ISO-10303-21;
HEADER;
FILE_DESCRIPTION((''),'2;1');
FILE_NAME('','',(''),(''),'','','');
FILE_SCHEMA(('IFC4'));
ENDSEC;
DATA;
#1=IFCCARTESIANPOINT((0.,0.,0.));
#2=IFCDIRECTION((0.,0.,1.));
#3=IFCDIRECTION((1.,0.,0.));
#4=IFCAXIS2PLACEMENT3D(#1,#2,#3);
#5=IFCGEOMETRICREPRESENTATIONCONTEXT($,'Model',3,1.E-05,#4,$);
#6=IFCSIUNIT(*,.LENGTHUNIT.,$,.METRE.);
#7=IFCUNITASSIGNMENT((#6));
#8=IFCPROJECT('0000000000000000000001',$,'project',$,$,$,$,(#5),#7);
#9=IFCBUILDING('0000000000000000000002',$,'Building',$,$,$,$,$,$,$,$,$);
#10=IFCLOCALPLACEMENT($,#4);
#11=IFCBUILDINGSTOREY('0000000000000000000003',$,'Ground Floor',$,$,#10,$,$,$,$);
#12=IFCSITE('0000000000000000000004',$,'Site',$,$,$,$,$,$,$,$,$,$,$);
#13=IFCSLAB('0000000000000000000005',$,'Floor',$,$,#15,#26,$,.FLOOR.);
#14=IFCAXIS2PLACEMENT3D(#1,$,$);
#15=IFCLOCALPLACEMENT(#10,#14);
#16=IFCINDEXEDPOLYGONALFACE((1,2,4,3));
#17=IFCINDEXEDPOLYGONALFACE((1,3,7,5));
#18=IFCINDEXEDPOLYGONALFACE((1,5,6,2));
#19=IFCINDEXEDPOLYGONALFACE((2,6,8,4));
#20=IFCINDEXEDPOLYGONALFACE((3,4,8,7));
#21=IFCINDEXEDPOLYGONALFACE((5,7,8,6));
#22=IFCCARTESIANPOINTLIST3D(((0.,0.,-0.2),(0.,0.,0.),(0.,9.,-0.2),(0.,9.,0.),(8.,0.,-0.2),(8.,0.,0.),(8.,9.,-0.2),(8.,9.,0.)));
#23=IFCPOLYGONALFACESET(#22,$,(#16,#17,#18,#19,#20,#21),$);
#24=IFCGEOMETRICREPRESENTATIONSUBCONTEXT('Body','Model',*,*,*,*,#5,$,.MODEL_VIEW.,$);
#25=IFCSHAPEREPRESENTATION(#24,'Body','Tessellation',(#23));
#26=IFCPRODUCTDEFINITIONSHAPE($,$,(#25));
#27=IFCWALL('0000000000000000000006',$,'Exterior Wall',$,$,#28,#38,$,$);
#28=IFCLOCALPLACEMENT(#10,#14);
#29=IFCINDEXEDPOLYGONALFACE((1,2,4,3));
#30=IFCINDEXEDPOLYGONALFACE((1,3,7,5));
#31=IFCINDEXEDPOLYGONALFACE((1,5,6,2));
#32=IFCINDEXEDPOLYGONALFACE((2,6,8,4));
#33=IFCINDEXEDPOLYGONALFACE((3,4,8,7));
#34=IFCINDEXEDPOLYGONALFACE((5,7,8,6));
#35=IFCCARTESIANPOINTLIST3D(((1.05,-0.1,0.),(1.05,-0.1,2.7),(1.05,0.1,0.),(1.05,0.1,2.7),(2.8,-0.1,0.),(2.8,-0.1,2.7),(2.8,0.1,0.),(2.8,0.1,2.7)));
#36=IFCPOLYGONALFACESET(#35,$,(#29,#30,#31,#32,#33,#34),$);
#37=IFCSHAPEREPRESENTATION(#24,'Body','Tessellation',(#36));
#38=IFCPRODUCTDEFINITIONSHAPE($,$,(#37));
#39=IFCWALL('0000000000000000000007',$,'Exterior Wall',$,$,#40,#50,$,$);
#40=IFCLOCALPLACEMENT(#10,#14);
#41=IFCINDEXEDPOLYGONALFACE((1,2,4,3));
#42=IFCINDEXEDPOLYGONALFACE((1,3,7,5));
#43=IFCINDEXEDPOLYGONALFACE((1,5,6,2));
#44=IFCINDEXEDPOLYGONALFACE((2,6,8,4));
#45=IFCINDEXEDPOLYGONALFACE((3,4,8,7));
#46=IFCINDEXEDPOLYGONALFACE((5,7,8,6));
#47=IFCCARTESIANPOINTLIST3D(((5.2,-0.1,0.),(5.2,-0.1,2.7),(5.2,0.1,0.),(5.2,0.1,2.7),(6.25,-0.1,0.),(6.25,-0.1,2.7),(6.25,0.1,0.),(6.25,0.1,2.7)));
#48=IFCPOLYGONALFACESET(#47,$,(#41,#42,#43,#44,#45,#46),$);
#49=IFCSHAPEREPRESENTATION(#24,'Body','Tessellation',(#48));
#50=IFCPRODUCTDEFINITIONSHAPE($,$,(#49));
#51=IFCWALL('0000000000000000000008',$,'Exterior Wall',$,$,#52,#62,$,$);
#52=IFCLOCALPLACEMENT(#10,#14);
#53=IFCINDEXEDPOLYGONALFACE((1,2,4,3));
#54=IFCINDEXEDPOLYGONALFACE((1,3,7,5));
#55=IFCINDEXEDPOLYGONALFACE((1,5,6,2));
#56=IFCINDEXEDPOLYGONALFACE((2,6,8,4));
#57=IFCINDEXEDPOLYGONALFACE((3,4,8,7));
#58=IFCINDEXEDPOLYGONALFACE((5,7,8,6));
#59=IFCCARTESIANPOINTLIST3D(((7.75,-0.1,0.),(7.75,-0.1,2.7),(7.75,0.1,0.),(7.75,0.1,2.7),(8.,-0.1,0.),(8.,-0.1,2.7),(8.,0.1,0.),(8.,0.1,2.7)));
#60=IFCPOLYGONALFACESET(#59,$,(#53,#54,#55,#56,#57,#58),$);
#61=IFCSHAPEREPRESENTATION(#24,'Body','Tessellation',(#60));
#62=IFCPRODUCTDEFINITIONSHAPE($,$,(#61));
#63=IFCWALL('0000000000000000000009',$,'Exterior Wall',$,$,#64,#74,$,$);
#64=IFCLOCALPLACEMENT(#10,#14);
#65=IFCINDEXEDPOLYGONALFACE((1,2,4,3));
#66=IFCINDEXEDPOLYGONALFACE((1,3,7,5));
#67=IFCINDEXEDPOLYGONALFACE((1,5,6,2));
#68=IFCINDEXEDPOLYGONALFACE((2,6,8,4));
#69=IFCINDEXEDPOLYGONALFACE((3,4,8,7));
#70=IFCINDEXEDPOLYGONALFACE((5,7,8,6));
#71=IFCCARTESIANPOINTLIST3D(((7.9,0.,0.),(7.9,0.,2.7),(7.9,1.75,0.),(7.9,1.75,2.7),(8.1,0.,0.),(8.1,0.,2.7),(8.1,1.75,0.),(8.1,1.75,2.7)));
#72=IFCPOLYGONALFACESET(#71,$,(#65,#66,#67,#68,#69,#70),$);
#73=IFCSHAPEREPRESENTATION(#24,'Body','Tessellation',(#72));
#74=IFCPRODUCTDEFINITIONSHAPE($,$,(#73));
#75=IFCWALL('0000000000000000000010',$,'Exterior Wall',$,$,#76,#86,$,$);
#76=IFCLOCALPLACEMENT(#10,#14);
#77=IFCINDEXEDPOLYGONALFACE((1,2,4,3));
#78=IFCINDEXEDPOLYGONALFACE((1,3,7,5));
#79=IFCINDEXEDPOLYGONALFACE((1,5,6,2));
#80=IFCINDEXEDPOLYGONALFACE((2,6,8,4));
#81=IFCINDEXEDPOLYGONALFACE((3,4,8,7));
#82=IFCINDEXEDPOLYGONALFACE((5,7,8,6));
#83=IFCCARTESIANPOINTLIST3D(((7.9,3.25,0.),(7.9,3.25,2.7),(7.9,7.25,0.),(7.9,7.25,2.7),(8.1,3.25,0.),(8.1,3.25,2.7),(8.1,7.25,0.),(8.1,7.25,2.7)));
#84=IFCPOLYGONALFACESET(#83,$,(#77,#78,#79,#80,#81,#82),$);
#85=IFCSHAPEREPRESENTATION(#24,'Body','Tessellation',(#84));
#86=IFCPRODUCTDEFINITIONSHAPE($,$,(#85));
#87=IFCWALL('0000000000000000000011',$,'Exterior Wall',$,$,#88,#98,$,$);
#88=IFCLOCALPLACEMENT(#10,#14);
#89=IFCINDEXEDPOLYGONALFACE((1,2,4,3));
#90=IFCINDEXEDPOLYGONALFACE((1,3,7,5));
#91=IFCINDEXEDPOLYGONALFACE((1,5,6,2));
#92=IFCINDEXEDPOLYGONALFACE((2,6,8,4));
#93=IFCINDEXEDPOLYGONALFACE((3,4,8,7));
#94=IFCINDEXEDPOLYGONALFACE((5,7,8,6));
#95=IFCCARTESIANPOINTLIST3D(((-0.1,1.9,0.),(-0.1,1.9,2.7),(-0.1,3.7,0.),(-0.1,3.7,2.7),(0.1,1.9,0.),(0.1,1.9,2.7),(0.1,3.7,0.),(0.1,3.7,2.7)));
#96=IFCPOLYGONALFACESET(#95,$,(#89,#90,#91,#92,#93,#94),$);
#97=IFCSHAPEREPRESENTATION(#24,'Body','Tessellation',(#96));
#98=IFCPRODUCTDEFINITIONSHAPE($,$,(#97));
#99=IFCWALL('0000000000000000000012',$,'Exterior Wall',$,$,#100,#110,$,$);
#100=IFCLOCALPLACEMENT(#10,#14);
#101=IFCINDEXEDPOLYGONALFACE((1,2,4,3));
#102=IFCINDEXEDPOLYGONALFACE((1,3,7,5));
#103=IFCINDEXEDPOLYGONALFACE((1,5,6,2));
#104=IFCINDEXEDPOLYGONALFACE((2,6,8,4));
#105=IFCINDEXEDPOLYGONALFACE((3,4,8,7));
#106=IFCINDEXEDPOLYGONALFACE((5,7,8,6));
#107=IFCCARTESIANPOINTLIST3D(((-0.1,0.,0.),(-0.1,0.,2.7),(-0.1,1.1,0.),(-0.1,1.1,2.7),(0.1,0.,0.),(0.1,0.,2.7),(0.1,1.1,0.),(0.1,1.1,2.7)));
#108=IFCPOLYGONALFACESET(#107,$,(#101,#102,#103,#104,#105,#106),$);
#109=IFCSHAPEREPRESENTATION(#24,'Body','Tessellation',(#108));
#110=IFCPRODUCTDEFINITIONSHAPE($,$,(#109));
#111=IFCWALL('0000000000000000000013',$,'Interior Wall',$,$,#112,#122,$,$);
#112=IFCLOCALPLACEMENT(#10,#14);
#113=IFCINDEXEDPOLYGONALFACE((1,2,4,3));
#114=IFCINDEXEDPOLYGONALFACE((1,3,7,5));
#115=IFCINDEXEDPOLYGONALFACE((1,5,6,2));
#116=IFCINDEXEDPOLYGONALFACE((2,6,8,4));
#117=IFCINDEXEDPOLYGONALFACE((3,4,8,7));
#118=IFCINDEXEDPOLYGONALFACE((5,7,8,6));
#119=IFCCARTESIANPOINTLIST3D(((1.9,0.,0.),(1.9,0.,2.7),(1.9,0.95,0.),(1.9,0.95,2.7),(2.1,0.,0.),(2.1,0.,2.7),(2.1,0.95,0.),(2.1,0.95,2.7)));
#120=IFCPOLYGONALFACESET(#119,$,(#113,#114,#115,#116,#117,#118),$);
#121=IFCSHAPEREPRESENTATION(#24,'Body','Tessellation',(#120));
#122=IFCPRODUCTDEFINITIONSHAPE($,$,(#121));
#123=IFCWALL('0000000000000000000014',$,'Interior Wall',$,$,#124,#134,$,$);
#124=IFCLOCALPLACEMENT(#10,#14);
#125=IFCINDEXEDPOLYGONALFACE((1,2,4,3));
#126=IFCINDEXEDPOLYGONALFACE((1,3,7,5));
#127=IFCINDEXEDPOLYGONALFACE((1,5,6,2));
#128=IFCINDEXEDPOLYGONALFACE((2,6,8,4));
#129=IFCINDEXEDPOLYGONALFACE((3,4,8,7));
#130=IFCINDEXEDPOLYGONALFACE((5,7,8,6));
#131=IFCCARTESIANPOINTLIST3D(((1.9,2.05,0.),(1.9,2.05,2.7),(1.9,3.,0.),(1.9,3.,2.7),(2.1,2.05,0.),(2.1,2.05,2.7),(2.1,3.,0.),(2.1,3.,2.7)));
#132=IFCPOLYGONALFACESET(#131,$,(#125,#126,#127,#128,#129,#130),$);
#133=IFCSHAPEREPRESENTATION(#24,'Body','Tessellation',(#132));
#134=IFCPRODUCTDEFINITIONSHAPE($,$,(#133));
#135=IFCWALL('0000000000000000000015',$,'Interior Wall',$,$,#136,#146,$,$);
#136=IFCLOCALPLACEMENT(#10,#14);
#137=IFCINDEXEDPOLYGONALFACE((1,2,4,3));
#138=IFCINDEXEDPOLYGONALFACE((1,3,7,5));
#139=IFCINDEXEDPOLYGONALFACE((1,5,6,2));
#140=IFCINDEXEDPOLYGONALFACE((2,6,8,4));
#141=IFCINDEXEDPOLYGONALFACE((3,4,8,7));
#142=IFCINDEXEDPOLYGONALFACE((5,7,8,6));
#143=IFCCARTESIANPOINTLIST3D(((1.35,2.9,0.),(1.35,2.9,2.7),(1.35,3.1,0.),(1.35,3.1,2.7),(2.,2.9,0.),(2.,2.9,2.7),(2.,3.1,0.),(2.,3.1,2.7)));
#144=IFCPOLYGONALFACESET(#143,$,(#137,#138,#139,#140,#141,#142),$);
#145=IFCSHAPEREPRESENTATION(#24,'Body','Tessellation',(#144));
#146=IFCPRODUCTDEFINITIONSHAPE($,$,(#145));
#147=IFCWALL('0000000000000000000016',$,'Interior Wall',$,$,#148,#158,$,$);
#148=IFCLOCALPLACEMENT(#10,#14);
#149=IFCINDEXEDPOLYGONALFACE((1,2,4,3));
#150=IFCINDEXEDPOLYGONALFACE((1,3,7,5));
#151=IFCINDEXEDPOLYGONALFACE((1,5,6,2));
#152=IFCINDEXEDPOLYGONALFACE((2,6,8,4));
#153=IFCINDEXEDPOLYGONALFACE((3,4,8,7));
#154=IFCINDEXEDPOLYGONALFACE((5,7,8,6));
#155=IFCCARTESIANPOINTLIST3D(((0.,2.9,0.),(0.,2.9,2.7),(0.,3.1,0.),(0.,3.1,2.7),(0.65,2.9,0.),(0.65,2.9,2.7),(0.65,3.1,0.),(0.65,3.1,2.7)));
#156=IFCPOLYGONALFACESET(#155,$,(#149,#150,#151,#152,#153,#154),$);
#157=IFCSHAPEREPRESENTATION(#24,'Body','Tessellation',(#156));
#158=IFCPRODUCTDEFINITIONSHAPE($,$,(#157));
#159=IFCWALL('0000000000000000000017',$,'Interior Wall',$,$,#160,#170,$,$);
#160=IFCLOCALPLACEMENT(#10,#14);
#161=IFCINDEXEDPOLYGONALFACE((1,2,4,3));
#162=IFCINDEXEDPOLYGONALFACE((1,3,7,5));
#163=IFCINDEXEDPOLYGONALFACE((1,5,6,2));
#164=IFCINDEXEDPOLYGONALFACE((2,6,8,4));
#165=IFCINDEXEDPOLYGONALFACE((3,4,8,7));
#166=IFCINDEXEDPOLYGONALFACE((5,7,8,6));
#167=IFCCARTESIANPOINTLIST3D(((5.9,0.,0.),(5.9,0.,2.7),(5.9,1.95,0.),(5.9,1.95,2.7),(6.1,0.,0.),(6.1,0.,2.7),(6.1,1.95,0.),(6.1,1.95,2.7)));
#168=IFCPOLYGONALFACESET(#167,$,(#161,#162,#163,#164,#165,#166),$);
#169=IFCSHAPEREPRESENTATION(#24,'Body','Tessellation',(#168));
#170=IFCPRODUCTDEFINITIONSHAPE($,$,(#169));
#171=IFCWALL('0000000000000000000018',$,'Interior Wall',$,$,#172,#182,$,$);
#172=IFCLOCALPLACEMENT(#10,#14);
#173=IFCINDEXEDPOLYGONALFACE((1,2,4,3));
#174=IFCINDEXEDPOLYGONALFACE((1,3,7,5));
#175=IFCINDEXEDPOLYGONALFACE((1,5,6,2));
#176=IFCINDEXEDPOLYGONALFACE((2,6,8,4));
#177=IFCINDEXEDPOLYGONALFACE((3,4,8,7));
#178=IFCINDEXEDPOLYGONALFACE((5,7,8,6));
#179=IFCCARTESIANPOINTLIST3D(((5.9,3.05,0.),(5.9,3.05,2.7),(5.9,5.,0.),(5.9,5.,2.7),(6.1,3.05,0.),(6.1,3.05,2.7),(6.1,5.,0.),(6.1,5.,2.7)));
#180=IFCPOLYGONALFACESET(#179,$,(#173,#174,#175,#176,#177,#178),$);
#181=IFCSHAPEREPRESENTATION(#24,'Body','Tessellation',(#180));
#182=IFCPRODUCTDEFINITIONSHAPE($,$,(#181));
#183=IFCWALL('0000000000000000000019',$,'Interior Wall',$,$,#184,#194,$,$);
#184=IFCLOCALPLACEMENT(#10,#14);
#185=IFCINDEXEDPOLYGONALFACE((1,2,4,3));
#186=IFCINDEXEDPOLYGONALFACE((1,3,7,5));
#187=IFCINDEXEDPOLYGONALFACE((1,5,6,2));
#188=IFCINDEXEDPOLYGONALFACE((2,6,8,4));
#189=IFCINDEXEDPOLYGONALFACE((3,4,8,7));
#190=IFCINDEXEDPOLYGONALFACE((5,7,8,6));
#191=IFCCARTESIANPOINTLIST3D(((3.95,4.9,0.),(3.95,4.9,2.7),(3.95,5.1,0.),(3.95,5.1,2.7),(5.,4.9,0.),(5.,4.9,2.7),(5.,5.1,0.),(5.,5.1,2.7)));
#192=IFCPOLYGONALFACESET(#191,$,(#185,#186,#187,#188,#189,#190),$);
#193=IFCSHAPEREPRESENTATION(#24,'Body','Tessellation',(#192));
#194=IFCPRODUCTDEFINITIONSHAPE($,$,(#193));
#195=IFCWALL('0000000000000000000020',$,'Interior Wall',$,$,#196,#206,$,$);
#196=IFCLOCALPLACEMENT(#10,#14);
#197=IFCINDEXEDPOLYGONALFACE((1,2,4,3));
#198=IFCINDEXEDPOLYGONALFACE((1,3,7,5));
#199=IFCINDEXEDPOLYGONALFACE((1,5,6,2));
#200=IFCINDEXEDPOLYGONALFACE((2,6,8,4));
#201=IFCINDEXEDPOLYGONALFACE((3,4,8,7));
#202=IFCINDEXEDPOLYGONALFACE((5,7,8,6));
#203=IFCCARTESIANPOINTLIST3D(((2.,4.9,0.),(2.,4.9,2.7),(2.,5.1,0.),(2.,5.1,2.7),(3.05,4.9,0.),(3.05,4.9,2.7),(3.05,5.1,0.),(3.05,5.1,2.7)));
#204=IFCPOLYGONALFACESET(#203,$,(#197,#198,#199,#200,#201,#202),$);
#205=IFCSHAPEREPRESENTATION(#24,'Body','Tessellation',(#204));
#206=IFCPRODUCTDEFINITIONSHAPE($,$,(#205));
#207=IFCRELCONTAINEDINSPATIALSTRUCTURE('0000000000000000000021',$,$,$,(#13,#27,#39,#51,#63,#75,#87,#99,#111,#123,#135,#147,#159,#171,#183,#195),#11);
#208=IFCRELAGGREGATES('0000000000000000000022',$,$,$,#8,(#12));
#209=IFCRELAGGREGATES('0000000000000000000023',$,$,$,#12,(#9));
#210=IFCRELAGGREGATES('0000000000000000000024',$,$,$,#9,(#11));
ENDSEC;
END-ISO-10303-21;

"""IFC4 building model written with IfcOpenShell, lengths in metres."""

from ifc_helpers import new_model, si_unit, frame, origin_with_axes, place, context, subcontext, project, spatial, indexed_curve, outline, extrude, element, save


model = new_model("IFC4")

# Units and contexts
model_context = context("Model", 3, precision=1e-05, world=origin_with_axes())
body_context = subcontext(model_context, "Body", "Model", "MODEL_VIEW")
ifc_project = project(units=[si_unit("LENGTHUNIT", "METRE")], contexts=[model_context])

# Site, building, storey
site = spatial("IfcSite", under=ifc_project, Name="Site")
building = spatial("IfcBuilding", under=site, Name="Building")
storey_placement = place(None, origin_with_axes())
storey = spatial("IfcBuildingStorey", under=building, at=storey_placement, Name="Ground Floor")

# Slab
slab_placement = place(storey_placement, frame((0.0, 0.0, -0.2), z_axis=(0.0, 0.0, 1.0), x_axis=(1.0, 0.0, 0.0)))
element("IfcSlab", 1, at=slab_placement, inside=storey, Name="Floor", PredefinedType="FLOOR", context=body_context, shape_type="SweptSolid", body=[
    extrude(outline(indexed_curve([(0.0, 0.0), (8.0, 0.0), (8.0, 9.0), (0.0, 9.0)])), None, (0.0, 0.0, 1.0), 0.2),
])

# Walls
wall_1_placement = place(storey_placement, frame((1.05, 0.0, 0.0), z_axis=(0.0, 0.0, 1.0), x_axis=(1.0, 0.0, 0.0)))
element("IfcWall", 2, at=wall_1_placement, inside=storey, Name="Exterior Wall", context=body_context, shape_type="SweptSolid", body=[
    extrude(outline(indexed_curve([(0.0, 0.0), (0.0, 0.2), (1.75, 0.2), (1.75, 0.0), (0.0, 0.0)], self_intersect=False)), frame((0.0, -0.1, 0.0), z_axis=(0.0, 0.0, 1.0), x_axis=(1.0, 0.0, 0.0)), (0.0, 0.0, 1.0), 2.7),
])
wall_2_placement = place(storey_placement, frame((5.2, 0.0, 0.0), z_axis=(0.0, 0.0, 1.0), x_axis=(1.0, 0.0, 0.0)))
element("IfcWall", 3, at=wall_2_placement, inside=storey, Name="Exterior Wall", context=body_context, shape_type="SweptSolid", body=[
    extrude(outline(indexed_curve([(0.0, 0.0), (0.0, 0.2), (1.05, 0.2), (1.05, 0.0), (0.0, 0.0)], self_intersect=False)), frame((0.0, -0.1, 0.0), z_axis=(0.0, 0.0, 1.0), x_axis=(1.0, 0.0, 0.0)), (0.0, 0.0, 1.0), 2.7),
])
wall_3_placement = place(storey_placement, frame((7.75, 0.0, 0.0), z_axis=(0.0, 0.0, 1.0), x_axis=(1.0, 0.0, 0.0)))
element("IfcWall", 4, at=wall_3_placement, inside=storey, Name="Exterior Wall", context=body_context, shape_type="SweptSolid", body=[
    extrude(outline(indexed_curve([(0.0, 0.0), (0.0, 0.2), (0.25, 0.2), (0.25, 0.0), (0.0, 0.0)], self_intersect=False)), frame((0.0, -0.1, 0.0), z_axis=(0.0, 0.0, 1.0), x_axis=(1.0, 0.0, 0.0)), (0.0, 0.0, 1.0), 2.7),
])
wall_4_placement = place(storey_placement, frame((8.0, 0.0, 0.0), z_axis=(0.0, 0.0, 1.0), x_axis=(0.0, 1.0, 0.0)))
element("IfcWall", 5, at=wall_4_placement, inside=storey, Name="Exterior Wall", context=body_context, shape_type="SweptSolid", body=[
    extrude(outline(indexed_curve([(0.0, 0.0), (0.0, 0.2), (1.75, 0.2), (1.75, 0.0), (0.0, 0.0)], self_intersect=False)), frame((0.0, -0.1, 0.0), z_axis=(0.0, 0.0, 1.0), x_axis=(1.0, 0.0, 0.0)), (0.0, 0.0, 1.0), 2.7),
])
wall_5_placement = place(storey_placement, frame((8.0, 3.25, 0.0), z_axis=(0.0, 0.0, 1.0), x_axis=(0.0, 1.0, 0.0)))
element("IfcWall", 6, at=wall_5_placement, inside=storey, Name="Exterior Wall", context=body_context, shape_type="SweptSolid", body=[
    extrude(outline(indexed_curve([(0.0, 0.0), (0.0, 0.2), (4.0, 0.2), (4.0, 0.0), (0.0, 0.0)], self_intersect=False)), frame((0.0, -0.1, 0.0), z_axis=(0.0, 0.0, 1.0), x_axis=(1.0, 0.0, 0.0)), (0.0, 0.0, 1.0), 2.7),
])
wall_6_placement = place(storey_placement, frame((0.0, 3.7, 0.0), z_axis=(0.0, 0.0, 1.0), x_axis=(0.0, -1.0, 0.0)))
element("IfcWall", 7, at=wall_6_placement, inside=storey, Name="Exterior Wall", context=body_context, shape_type="SweptSolid", body=[
    extrude(outline(indexed_curve([(0.0, 0.0), (0.0, 0.2), (1.8, 0.2), (1.8, 0.0), (0.0, 0.0)], self_intersect=False)), frame((0.0, -0.1, 0.0), z_axis=(0.0, 0.0, 1.0), x_axis=(1.0, 0.0, 0.0)), (0.0, 0.0, 1.0), 2.7),
])
wall_7_placement = place(storey_placement, frame((0.0, 1.1, 0.0), z_axis=(0.0, 0.0, 1.0), x_axis=(0.0, -1.0, 0.0)))
element("IfcWall", 8, at=wall_7_placement, inside=storey, Name="Exterior Wall", context=body_context, shape_type="SweptSolid", body=[
    extrude(outline(indexed_curve([(0.0, 0.0), (0.0, 0.2), (1.1, 0.2), (1.1, 0.0), (0.0, 0.0)], self_intersect=False)), frame((0.0, -0.1, 0.0), z_axis=(0.0, 0.0, 1.0), x_axis=(1.0, 0.0, 0.0)), (0.0, 0.0, 1.0), 2.7),
])
wall_8_placement = place(storey_placement, frame((2.0, 0.0, 0.0), z_axis=(0.0, 0.0, 1.0), x_axis=(0.0, 1.0, 0.0)))
element("IfcWall", 9, at=wall_8_placement, inside=storey, Name="Interior Wall", context=body_context, shape_type="SweptSolid", body=[
    extrude(outline(indexed_curve([(0.0, 0.0), (0.0, 0.2), (0.95, 0.2), (0.95, 0.0), (0.0, 0.0)], self_intersect=False)), frame((0.0, -0.1, 0.0), z_axis=(0.0, 0.0, 1.0), x_axis=(1.0, 0.0, 0.0)), (0.0, 0.0, 1.0), 2.7),
])
wall_9_placement = place(storey_placement, frame((2.0, 2.05, 0.0), z_axis=(0.0, 0.0, 1.0), x_axis=(0.0, 1.0, 0.0)))
element("IfcWall", 10, at=wall_9_placement, inside=storey, Name="Interior Wall", context=body_context, shape_type="SweptSolid", body=[
    extrude(outline(indexed_curve([(0.0, 0.0), (0.0, 0.2), (0.95, 0.2), (0.95, 0.0), (0.0, 0.0)], self_intersect=False)), frame((0.0, -0.1, 0.0), z_axis=(0.0, 0.0, 1.0), x_axis=(1.0, 0.0, 0.0)), (0.0, 0.0, 1.0), 2.7),
])
for number, where, z_axis, x_axis, name in (
    (11, (2.0, 3.0, 0.0), (0.0, 0.0, 1.0), (-1.0, 0.0, 0.0), "Interior Wall"),
    (12, (0.65, 3.0, 0.0), (0.0, 0.0, 1.0), (-1.0, 0.0, 0.0), "Interior Wall"),
):
    element("IfcWall", number, at=place(storey_placement, frame(where, z_axis=z_axis, x_axis=x_axis)), inside=storey, Name=name, context=body_context, shape_type="SweptSolid", body=[
        extrude(outline(indexed_curve([(0.0, 0.0), (0.0, 0.2), (0.65, 0.2), (0.65, 0.0), (0.0, 0.0)], self_intersect=False)), frame((0.0, -0.1, 0.0), z_axis=(0.0, 0.0, 1.0), x_axis=(1.0, 0.0, 0.0)), (0.0, 0.0, 1.0), 2.7),
    ])
wall_10_placement = place(storey_placement, frame((6.0, 0.0, 0.0), z_axis=(0.0, 0.0, 1.0), x_axis=(0.0, 1.0, 0.0)))
element("IfcWall", 13, at=wall_10_placement, inside=storey, Name="Interior Wall", context=body_context, shape_type="SweptSolid", body=[
    extrude(outline(indexed_curve([(0.0, 0.0), (0.0, 0.2), (1.95, 0.2), (1.95, 0.0), (0.0, 0.0)], self_intersect=False)), frame((0.0, -0.1, 0.0), z_axis=(0.0, 0.0, 1.0), x_axis=(1.0, 0.0, 0.0)), (0.0, 0.0, 1.0), 2.7),
])
wall_11_placement = place(storey_placement, frame((6.0, 3.05, 0.0), z_axis=(0.0, 0.0, 1.0), x_axis=(0.0, 1.0, 0.0)))
element("IfcWall", 14, at=wall_11_placement, inside=storey, Name="Interior Wall", context=body_context, shape_type="SweptSolid", body=[
    extrude(outline(indexed_curve([(0.0, 0.0), (0.0, 0.2), (1.95, 0.2), (1.95, 0.0), (0.0, 0.0)], self_intersect=False)), frame((0.0, -0.1, 0.0), z_axis=(0.0, 0.0, 1.0), x_axis=(1.0, 0.0, 0.0)), (0.0, 0.0, 1.0), 2.7),
])
for number, where, z_axis, x_axis, name in (
    (15, (5.0, 5.0, 0.0), (0.0, 0.0, 1.0), (-1.0, 0.0, 0.0), "Interior Wall"),
    (16, (3.05, 5.0, 0.0), (0.0, 0.0, 1.0), (-1.0, 0.0, 0.0), "Interior Wall"),
):
    element("IfcWall", number, at=place(storey_placement, frame(where, z_axis=z_axis, x_axis=x_axis)), inside=storey, Name=name, context=body_context, shape_type="SweptSolid", body=[
        extrude(outline(indexed_curve([(0.0, 0.0), (0.0, 0.2), (1.05, 0.2), (1.05, 0.0), (0.0, 0.0)], self_intersect=False)), frame((0.0, -0.1, 0.0), z_axis=(0.0, 0.0, 1.0), x_axis=(1.0, 0.0, 0.0)), (0.0, 0.0, 1.0), 2.7),
    ])

save(model, "model.ifc")
